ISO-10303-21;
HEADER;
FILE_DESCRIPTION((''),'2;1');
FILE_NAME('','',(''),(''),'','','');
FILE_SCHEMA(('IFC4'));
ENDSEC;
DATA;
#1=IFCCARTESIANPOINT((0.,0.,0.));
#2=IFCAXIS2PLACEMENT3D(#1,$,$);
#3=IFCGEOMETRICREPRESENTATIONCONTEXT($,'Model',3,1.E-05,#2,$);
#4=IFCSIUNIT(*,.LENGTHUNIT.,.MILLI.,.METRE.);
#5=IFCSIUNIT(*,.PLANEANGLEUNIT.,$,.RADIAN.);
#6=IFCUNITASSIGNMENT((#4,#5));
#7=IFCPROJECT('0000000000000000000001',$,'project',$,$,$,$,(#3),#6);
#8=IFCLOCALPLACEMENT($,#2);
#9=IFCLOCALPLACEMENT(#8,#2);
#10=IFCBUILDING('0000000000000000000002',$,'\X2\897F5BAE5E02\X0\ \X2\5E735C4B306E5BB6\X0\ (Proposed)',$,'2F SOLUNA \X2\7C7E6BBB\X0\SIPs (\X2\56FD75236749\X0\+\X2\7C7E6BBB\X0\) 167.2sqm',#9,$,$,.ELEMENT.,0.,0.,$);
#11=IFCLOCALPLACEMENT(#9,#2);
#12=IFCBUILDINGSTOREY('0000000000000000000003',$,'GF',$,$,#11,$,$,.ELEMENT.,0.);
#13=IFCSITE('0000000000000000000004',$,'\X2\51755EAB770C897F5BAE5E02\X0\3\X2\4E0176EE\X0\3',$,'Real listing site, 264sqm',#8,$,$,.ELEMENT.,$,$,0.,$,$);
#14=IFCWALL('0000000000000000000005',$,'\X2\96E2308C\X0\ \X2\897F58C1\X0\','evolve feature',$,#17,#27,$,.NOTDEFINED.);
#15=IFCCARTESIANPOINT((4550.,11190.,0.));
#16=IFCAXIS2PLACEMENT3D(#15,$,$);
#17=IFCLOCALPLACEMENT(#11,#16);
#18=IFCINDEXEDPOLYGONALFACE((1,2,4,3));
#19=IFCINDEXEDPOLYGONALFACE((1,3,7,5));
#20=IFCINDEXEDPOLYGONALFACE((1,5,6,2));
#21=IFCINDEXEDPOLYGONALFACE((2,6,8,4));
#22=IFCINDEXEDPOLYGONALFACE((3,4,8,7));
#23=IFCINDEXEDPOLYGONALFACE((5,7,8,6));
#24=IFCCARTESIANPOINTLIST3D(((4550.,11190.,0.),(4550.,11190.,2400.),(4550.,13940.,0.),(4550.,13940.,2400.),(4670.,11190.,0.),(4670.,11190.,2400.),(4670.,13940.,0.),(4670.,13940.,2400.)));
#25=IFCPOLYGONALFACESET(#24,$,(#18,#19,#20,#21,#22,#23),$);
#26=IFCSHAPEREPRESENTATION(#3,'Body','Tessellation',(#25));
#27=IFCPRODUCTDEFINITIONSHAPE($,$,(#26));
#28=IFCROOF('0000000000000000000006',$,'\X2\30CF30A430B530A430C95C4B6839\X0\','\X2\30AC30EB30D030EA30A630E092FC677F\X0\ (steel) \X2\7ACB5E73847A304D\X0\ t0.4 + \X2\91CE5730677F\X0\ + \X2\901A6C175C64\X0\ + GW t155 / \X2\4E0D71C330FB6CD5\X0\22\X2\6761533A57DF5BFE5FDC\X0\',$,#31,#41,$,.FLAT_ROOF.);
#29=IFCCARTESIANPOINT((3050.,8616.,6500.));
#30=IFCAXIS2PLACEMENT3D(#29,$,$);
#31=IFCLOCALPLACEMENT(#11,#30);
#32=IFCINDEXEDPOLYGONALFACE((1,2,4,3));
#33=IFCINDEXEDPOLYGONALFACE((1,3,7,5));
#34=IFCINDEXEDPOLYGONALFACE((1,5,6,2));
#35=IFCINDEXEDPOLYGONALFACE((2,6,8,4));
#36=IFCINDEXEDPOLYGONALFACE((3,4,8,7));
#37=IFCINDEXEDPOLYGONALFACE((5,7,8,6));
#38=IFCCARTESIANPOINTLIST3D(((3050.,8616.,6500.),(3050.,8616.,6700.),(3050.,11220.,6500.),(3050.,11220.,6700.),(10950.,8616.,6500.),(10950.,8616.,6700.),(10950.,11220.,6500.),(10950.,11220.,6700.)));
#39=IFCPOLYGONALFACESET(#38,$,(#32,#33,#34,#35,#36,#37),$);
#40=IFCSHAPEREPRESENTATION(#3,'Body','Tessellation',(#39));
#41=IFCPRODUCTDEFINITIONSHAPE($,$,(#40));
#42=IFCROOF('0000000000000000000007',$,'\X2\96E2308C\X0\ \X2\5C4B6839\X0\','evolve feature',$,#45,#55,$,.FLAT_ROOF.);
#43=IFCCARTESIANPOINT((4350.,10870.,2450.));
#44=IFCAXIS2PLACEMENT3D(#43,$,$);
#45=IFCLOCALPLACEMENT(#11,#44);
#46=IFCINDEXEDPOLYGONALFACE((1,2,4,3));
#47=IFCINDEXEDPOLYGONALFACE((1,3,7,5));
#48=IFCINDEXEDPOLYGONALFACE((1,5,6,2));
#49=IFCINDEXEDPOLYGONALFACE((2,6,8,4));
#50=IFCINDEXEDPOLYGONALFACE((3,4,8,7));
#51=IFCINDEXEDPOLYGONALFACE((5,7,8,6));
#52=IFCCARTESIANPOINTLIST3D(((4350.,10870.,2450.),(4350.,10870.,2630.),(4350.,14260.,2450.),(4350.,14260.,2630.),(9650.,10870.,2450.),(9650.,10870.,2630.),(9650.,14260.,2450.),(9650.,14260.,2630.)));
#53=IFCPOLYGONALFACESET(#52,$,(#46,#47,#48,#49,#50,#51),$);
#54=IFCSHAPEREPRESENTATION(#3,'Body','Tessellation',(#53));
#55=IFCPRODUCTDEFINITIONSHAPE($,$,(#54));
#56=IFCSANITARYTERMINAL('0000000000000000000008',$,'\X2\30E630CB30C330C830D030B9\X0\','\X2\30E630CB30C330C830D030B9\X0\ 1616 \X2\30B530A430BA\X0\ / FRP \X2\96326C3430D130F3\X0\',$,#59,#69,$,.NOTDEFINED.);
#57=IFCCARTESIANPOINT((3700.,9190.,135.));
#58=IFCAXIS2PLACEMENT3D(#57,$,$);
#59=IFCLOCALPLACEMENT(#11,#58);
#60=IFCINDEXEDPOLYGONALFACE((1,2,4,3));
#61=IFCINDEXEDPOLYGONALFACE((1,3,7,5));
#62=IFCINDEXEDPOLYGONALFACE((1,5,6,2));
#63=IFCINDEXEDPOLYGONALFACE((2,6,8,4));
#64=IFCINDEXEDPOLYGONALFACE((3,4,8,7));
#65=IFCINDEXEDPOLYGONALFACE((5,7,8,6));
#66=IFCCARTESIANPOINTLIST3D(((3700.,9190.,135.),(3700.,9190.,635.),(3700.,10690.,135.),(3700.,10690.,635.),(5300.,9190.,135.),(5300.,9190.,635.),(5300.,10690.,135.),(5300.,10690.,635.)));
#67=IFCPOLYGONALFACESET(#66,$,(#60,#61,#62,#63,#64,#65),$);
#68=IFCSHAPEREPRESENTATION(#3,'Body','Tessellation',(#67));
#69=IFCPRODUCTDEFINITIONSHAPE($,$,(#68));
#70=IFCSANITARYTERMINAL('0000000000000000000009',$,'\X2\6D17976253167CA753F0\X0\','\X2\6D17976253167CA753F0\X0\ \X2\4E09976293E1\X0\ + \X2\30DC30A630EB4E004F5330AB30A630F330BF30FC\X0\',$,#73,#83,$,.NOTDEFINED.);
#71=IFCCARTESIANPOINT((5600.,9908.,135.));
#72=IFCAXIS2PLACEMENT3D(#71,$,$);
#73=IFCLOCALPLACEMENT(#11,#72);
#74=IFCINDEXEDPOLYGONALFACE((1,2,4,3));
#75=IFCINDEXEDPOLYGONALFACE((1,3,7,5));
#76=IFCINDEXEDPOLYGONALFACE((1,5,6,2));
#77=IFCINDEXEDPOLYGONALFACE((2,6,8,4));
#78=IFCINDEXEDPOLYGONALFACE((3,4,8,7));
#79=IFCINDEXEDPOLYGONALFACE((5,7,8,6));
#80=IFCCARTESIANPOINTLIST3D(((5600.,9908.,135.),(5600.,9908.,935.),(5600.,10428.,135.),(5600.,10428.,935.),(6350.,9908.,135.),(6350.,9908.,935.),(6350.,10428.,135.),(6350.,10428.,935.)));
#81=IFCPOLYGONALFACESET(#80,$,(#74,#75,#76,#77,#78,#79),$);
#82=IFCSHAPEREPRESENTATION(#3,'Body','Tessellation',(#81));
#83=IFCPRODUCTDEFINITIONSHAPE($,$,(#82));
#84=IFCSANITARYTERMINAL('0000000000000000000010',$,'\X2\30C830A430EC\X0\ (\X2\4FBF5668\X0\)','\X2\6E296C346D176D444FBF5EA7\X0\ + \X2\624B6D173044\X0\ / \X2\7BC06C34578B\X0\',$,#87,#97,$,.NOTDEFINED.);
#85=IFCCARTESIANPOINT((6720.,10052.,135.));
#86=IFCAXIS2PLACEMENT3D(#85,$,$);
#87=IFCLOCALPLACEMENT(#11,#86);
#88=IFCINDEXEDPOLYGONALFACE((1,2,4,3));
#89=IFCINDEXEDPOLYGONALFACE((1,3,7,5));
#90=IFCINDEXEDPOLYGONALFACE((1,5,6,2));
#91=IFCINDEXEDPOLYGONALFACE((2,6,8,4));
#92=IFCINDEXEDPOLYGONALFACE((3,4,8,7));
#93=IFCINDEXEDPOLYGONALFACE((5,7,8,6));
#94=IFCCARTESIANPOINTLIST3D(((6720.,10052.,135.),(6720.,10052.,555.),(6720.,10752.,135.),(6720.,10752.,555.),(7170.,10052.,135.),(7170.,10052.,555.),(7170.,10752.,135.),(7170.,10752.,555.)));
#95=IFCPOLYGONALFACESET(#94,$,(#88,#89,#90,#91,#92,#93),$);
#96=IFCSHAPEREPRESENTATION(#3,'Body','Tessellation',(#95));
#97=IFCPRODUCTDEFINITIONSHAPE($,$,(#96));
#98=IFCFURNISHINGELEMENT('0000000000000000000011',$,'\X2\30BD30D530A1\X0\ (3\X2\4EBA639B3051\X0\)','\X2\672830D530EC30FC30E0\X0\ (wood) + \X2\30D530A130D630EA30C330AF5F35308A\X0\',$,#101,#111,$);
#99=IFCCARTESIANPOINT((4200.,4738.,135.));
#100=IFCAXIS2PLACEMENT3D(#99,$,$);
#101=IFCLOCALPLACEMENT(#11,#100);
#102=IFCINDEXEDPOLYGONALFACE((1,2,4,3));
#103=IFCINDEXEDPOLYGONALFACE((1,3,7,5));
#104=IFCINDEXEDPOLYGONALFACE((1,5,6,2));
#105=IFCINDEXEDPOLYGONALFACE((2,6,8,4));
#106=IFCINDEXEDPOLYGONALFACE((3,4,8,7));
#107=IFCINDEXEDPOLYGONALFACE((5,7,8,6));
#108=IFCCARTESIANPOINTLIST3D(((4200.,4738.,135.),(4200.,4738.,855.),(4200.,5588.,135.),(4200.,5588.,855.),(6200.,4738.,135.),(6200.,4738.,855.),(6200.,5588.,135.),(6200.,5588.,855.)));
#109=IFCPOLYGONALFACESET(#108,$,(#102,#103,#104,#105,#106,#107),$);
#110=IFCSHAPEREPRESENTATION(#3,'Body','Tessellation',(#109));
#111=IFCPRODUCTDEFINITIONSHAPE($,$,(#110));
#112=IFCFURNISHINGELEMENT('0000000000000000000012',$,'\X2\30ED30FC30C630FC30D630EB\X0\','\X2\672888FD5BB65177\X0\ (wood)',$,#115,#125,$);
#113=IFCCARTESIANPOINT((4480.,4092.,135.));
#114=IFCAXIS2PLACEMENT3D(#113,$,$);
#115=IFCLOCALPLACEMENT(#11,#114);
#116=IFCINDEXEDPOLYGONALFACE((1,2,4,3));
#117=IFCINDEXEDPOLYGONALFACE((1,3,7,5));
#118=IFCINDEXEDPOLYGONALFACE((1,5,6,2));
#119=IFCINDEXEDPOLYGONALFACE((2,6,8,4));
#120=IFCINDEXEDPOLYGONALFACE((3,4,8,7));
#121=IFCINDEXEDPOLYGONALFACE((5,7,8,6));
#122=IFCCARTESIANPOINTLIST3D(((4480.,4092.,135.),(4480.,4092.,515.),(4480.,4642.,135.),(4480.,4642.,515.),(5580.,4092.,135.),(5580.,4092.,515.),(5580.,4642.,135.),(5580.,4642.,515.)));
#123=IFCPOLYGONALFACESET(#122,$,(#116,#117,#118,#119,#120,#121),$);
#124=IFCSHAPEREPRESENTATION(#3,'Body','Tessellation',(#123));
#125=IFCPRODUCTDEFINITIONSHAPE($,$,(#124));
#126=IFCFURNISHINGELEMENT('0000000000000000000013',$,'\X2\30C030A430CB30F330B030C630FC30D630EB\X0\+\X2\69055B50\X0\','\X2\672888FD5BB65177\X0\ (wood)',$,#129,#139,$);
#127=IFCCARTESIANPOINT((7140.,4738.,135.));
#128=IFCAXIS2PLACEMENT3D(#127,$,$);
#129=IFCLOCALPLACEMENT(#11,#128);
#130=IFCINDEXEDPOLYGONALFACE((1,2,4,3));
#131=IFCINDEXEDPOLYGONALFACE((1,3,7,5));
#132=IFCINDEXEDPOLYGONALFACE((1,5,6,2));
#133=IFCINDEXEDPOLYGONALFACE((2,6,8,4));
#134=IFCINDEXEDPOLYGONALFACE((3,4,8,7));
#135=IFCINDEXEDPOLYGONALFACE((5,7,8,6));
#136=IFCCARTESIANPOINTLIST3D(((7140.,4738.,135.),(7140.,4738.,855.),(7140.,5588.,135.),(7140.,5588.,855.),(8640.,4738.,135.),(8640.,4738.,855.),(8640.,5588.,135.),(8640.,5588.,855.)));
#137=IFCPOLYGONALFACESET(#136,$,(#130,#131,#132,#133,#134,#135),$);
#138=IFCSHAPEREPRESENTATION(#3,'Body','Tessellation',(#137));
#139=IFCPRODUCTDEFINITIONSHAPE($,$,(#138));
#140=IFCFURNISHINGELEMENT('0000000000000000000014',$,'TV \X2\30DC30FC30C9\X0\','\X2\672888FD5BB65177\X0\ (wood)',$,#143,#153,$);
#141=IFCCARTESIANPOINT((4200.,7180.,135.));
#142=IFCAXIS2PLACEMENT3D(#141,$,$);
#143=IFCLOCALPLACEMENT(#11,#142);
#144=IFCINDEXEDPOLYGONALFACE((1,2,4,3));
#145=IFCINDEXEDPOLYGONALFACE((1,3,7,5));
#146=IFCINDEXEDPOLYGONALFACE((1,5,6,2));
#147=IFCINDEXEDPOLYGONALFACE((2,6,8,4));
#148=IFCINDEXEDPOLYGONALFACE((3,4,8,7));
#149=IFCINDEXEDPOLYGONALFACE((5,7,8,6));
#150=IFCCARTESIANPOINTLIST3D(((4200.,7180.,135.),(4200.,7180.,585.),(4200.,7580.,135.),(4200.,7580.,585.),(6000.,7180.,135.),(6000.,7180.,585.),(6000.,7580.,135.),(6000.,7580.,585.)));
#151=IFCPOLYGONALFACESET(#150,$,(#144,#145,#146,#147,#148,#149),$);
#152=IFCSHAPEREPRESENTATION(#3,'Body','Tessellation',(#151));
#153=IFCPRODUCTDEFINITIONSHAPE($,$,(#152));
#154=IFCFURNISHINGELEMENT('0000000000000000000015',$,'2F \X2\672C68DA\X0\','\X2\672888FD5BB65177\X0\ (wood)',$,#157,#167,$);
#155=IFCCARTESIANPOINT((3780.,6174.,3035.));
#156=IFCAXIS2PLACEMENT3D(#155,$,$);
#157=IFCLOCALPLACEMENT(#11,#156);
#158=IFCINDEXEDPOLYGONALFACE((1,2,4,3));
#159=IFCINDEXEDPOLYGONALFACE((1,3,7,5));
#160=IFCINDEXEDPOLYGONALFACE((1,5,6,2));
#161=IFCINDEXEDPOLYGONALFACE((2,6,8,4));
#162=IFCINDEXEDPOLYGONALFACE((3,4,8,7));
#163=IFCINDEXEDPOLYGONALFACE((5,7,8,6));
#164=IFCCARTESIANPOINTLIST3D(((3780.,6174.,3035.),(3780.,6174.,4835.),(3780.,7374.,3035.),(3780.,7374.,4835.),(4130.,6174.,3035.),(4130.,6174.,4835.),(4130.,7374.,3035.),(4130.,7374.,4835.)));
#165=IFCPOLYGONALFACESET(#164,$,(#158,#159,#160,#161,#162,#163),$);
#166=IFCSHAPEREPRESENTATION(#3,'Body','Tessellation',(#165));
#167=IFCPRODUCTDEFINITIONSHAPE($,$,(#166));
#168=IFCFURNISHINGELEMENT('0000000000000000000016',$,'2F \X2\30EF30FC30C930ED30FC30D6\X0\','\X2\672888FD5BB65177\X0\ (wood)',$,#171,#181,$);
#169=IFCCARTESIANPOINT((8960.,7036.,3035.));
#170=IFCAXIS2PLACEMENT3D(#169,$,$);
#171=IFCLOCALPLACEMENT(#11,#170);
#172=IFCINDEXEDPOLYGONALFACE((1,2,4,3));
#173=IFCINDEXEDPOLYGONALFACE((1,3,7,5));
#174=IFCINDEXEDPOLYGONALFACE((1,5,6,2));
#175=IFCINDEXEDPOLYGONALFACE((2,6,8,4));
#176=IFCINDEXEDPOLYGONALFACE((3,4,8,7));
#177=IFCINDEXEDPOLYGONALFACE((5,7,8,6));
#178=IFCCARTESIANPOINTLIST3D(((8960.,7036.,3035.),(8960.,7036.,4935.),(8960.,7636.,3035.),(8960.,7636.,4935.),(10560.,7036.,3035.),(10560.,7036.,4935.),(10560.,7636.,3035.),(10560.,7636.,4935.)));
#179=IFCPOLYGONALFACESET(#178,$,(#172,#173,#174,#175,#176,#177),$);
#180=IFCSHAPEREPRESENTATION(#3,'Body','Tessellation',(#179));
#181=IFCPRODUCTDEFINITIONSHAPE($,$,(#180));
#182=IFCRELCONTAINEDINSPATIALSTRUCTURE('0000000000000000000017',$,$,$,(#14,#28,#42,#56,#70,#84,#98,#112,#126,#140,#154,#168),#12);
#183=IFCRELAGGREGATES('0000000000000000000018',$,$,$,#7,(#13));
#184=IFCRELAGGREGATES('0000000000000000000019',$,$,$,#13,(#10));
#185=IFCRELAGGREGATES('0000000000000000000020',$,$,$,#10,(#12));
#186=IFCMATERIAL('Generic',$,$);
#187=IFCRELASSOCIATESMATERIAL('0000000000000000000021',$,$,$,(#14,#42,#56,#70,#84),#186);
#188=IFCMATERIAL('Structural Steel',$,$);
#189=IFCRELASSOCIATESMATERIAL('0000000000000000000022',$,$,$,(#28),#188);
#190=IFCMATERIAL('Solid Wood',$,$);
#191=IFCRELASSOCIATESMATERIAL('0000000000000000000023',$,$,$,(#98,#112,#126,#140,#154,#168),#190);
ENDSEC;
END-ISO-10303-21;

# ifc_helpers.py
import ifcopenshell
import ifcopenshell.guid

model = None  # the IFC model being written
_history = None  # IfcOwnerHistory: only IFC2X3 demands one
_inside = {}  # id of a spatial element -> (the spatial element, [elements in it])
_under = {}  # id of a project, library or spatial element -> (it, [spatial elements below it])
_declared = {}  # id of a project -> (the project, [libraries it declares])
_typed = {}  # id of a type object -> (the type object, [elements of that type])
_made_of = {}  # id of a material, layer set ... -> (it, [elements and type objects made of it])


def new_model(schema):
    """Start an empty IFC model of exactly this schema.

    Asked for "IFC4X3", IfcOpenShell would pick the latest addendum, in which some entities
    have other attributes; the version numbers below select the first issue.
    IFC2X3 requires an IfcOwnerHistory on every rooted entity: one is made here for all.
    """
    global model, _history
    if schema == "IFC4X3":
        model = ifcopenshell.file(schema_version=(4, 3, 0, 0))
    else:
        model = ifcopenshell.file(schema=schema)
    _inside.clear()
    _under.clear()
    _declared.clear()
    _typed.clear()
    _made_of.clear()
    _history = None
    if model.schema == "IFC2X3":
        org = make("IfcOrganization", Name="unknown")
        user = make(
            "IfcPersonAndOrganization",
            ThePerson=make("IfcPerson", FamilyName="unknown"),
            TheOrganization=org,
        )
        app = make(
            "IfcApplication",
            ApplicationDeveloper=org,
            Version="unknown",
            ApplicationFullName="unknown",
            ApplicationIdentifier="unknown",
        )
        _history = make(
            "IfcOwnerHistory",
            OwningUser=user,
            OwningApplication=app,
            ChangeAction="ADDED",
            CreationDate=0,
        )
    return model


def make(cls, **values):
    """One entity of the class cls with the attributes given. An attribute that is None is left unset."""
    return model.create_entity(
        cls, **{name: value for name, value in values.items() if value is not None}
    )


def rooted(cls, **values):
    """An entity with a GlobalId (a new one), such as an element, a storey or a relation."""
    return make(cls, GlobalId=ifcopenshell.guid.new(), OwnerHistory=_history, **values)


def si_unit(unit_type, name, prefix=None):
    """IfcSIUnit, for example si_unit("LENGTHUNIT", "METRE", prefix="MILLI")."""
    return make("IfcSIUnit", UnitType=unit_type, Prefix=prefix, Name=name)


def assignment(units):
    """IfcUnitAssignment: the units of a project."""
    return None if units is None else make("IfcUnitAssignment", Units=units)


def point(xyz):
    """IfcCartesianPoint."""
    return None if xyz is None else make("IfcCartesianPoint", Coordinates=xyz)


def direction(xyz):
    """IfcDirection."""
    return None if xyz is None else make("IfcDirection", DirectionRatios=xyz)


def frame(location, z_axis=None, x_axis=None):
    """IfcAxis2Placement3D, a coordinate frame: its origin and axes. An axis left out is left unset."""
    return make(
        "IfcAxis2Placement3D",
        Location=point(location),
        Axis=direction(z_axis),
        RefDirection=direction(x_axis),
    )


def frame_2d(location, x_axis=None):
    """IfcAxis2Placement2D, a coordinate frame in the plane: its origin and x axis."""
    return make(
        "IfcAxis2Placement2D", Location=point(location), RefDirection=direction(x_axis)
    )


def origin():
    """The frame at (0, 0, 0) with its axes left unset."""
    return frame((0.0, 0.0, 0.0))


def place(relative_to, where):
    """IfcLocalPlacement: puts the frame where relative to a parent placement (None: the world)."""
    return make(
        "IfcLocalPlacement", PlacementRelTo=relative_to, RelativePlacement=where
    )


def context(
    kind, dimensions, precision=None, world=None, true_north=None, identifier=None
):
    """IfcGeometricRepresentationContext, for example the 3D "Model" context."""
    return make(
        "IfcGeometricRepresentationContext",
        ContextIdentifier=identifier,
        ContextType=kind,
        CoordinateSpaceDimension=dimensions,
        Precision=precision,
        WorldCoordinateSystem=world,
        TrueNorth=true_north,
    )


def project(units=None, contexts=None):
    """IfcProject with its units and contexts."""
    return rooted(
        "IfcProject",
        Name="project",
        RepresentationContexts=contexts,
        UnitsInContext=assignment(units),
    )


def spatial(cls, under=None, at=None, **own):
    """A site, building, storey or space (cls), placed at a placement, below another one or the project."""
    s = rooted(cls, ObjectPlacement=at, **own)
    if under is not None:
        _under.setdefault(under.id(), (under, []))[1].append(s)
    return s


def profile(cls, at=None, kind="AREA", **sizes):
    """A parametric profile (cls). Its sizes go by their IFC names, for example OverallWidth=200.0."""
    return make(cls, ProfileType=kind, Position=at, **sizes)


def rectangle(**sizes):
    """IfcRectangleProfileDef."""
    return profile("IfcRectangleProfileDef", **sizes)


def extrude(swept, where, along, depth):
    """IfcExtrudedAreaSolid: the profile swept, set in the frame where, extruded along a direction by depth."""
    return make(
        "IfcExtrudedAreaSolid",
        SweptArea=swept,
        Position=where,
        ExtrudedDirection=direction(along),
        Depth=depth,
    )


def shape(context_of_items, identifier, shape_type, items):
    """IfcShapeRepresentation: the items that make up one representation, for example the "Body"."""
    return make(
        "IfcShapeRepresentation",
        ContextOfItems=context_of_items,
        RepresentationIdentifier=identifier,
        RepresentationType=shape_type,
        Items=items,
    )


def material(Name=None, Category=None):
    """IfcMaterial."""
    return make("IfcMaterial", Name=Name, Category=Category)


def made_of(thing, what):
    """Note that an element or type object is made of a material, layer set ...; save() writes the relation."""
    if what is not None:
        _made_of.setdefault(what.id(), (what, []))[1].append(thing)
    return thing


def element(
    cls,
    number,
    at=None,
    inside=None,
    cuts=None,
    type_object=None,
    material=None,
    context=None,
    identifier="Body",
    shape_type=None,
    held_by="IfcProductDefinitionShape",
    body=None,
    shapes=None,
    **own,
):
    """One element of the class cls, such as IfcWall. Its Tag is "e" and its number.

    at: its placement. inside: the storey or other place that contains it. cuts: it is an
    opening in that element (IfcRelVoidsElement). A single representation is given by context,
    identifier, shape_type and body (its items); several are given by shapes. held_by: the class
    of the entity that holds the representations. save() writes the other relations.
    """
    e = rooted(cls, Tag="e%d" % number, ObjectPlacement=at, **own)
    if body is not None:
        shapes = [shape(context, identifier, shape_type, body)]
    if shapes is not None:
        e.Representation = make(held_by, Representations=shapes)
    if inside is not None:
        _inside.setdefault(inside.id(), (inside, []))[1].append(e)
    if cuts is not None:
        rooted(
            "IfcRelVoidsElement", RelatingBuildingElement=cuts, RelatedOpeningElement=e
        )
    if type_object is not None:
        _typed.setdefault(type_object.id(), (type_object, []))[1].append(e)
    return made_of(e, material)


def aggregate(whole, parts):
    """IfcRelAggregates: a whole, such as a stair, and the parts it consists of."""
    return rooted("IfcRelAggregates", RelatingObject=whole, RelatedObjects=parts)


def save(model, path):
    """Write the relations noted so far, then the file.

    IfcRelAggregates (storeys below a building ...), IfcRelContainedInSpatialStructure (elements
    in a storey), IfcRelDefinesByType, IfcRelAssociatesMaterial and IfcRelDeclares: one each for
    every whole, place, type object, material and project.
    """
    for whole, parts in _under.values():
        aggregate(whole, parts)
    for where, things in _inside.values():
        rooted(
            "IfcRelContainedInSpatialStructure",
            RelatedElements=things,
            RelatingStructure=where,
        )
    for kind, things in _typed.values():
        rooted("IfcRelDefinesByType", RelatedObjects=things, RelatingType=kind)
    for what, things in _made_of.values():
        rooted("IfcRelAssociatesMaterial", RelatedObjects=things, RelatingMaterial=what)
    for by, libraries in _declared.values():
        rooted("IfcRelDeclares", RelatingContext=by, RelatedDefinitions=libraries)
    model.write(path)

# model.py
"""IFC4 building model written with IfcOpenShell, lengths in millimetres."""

from ifc_helpers import new_model, si_unit, frame, frame_2d, origin, place, context, project, spatial, rectangle, extrude, material, element, save


model = new_model("IFC4")

# Units and contexts
model_context = context("Model", 3, precision=1e-05, world=origin())
ifc_project = project(units=[si_unit("LENGTHUNIT", "METRE", prefix="MILLI"), si_unit("PLANEANGLEUNIT", "RADIAN")], contexts=[model_context])

# Site, building, storey
site_placement = place(None, origin())
site = spatial("IfcSite", under=ifc_project, at=site_placement, Name="兵庫県西宮市3丁目3", ObjectType="Real listing site, 264sqm", CompositionType="ELEMENT", RefElevation=0.0)
building_placement = place(site_placement, origin())
building = spatial("IfcBuilding", under=site, at=building_placement, Name="西宮市 平屋の家 (Proposed)", ObjectType="2F SOLUNA 籾殻SIPs (国産杉+籾殻) 167.2sqm", CompositionType="ELEMENT", ElevationOfRefHeight=0.0, ElevationOfTerrain=0.0)
storey_placement = place(building_placement, origin())
storey = spatial("IfcBuildingStorey", under=building, at=storey_placement, Name="GF", CompositionType="ELEMENT", Elevation=0.0)

# Shared definitions
ifc_material_1 = material(Name="Generic")

# Shared definitions
ifc_material_2 = material(Name="Solid Wood")

# Wall
wall_1_placement = place(storey_placement, frame((4550.0, 11190.0, 0.0)))
element("IfcWall", 1, at=wall_1_placement, inside=storey, material=ifc_material_1, Name="離れ 西壁", Description="evolve feature", PredefinedType="NOTDEFINED", context=model_context, shape_type="SweptSolid", body=[
    extrude(rectangle(XDim=120.0, YDim=2750.0, at=frame_2d((60.0, 1375.0))), frame((4550.0, 11190.0, 0.0)), (0.0, 0.0, 1.0), 2400.0),
])

# Roofs
ifc_material_3 = material(Name="Structural Steel")
roof_1_placement = place(storey_placement, frame((3050.0, 8616.0, 6500.0)))
element("IfcRoof", 2, at=roof_1_placement, inside=storey, material=ifc_material_3, Name="ハイサイド屋根", Description="ガルバリウム鋼板 (steel) 立平葺き t0.4 + 野地板 + 通気層 + GW t155 / 不燃・法22条区域対応", PredefinedType="FLAT_ROOF", context=model_context, shape_type="SweptSolid", body=[
    extrude(rectangle(XDim=7900.0, YDim=2604.0, at=frame_2d((3950.0, 1302.0))), frame((3050.0, 8616.0, 6500.0)), (0.0, 0.0, 1.0), 200.0),
])
roof_2_placement = place(storey_placement, frame((4350.0, 10870.0, 2450.0)))
element("IfcRoof", 3, at=roof_2_placement, inside=storey, material=ifc_material_1, Name="離れ 屋根", Description="evolve feature", PredefinedType="FLAT_ROOF", context=model_context, shape_type="SweptSolid", body=[
    extrude(rectangle(XDim=5300.0, YDim=3390.0, at=frame_2d((2650.0, 1695.0))), frame((4350.0, 10870.0, 2450.0)), (0.0, 0.0, 1.0), 180.0),
])

# Sanitary terminals
sanitary_terminal_1_placement = place(storey_placement, frame((3700.0, 9190.0, 135.0)))
element("IfcSanitaryTerminal", 4, at=sanitary_terminal_1_placement, inside=storey, material=ifc_material_1, Name="ユニットバス", Description="ユニットバス 1616 サイズ / FRP 防水パン", PredefinedType="NOTDEFINED", context=model_context, shape_type="SweptSolid", body=[
    extrude(rectangle(XDim=1600.0, YDim=1500.0, at=frame_2d((800.0, 750.0))), frame((3700.0, 9190.0, 135.0)), (0.0, 0.0, 1.0), 500.0),
])
sanitary_terminal_2_placement = place(storey_placement, frame((5600.0, 9908.0, 135.0)))
element("IfcSanitaryTerminal", 5, at=sanitary_terminal_2_placement, inside=storey, material=ifc_material_1, Name="洗面化粧台", Description="洗面化粧台 三面鏡 + ボウル一体カウンター", PredefinedType="NOTDEFINED", context=model_context, shape_type="SweptSolid", body=[
    extrude(rectangle(XDim=750.0, YDim=520.0, at=frame_2d((375.0, 260.0))), frame((5600.0, 9908.0, 135.0)), (0.0, 0.0, 1.0), 800.0),
])
sanitary_terminal_3_placement = place(storey_placement, frame((6720.0, 10052.0, 135.0)))
element("IfcSanitaryTerminal", 6, at=sanitary_terminal_3_placement, inside=storey, material=ifc_material_1, Name="トイレ (便器)", Description="温水洗浄便座 + 手洗い / 節水型", PredefinedType="NOTDEFINED", context=model_context, shape_type="SweptSolid", body=[
    extrude(rectangle(XDim=450.0, YDim=700.0, at=frame_2d((225.0, 350.0))), frame((6720.0, 10052.0, 135.0)), (0.0, 0.0, 1.0), 420.0),
])

# Furnishing elements
furnishing_1_placement = place(storey_placement, frame((4200.0, 4738.0, 135.0)))
element("IfcFurnishingElement", 7, at=furnishing_1_placement, inside=storey, material=ifc_material_2, Name="ソファ (3人掛け)", Description="木フレーム (wood) + ファブリック張り", context=model_context, shape_type="SweptSolid", body=[
    extrude(rectangle(XDim=2000.0, YDim=850.0, at=frame_2d((1000.0, 425.0))), frame((4200.0, 4738.0, 135.0)), (0.0, 0.0, 1.0), 720.0),
])
furnishing_2_placement = place(storey_placement, frame((4480.0, 4092.0, 135.0)))
element("IfcFurnishingElement", 8, at=furnishing_2_placement, inside=storey, material=ifc_material_2, Name="ローテーブル", Description="木製家具 (wood)", context=model_context, shape_type="SweptSolid", body=[
    extrude(rectangle(XDim=1100.0, YDim=550.0, at=frame_2d((550.0, 275.0))), frame((4480.0, 4092.0, 135.0)), (0.0, 0.0, 1.0), 380.0),
])
furnishing_3_placement = place(storey_placement, frame((7140.0, 4738.0, 135.0)))
element("IfcFurnishingElement", 9, at=furnishing_3_placement, inside=storey, material=ifc_material_2, Name="ダイニングテーブル+椅子", Description="木製家具 (wood)", context=model_context, shape_type="SweptSolid", body=[
    extrude(rectangle(XDim=1500.0, YDim=850.0, at=frame_2d((750.0, 425.0))), frame((7140.0, 4738.0, 135.0)), (0.0, 0.0, 1.0), 720.0),
])
furnishing_4_placement = place(storey_placement, frame((4200.0, 7180.0, 135.0)))
element("IfcFurnishingElement", 10, at=furnishing_4_placement, inside=storey, material=ifc_material_2, Name="TV ボード", Description="木製家具 (wood)", context=model_context, shape_type="SweptSolid", body=[
    extrude(rectangle(XDim=1800.0, YDim=400.0, at=frame_2d((900.0, 200.0))), frame((4200.0, 7180.0, 135.0)), (0.0, 0.0, 1.0), 450.0),
])
furnishing_5_placement = place(storey_placement, frame((3780.0, 6174.0, 3035.0)))
element("IfcFurnishingElement", 11, at=furnishing_5_placement, inside=storey, material=ifc_material_2, Name="2F 本棚", Description="木製家具 (wood)", context=model_context, shape_type="SweptSolid", body=[
    extrude(rectangle(XDim=350.0, YDim=1200.0, at=frame_2d((175.0, 600.0))), frame((3780.0, 6174.0, 3035.0)), (0.0, 0.0, 1.0), 1800.0),
])
furnishing_6_placement = place(storey_placement, frame((8960.0, 7036.0, 3035.0)))
element("IfcFurnishingElement", 12, at=furnishing_6_placement, inside=storey, material=ifc_material_2, Name="2F ワードローブ", Description="木製家具 (wood)", context=model_context, shape_type="SweptSolid", body=[
    extrude(rectangle(XDim=1600.0, YDim=600.0, at=frame_2d((800.0, 300.0))), frame((8960.0, 7036.0, 3035.0)), (0.0, 0.0, 1.0), 1900.0),
])

save(model, "model.ifc")
